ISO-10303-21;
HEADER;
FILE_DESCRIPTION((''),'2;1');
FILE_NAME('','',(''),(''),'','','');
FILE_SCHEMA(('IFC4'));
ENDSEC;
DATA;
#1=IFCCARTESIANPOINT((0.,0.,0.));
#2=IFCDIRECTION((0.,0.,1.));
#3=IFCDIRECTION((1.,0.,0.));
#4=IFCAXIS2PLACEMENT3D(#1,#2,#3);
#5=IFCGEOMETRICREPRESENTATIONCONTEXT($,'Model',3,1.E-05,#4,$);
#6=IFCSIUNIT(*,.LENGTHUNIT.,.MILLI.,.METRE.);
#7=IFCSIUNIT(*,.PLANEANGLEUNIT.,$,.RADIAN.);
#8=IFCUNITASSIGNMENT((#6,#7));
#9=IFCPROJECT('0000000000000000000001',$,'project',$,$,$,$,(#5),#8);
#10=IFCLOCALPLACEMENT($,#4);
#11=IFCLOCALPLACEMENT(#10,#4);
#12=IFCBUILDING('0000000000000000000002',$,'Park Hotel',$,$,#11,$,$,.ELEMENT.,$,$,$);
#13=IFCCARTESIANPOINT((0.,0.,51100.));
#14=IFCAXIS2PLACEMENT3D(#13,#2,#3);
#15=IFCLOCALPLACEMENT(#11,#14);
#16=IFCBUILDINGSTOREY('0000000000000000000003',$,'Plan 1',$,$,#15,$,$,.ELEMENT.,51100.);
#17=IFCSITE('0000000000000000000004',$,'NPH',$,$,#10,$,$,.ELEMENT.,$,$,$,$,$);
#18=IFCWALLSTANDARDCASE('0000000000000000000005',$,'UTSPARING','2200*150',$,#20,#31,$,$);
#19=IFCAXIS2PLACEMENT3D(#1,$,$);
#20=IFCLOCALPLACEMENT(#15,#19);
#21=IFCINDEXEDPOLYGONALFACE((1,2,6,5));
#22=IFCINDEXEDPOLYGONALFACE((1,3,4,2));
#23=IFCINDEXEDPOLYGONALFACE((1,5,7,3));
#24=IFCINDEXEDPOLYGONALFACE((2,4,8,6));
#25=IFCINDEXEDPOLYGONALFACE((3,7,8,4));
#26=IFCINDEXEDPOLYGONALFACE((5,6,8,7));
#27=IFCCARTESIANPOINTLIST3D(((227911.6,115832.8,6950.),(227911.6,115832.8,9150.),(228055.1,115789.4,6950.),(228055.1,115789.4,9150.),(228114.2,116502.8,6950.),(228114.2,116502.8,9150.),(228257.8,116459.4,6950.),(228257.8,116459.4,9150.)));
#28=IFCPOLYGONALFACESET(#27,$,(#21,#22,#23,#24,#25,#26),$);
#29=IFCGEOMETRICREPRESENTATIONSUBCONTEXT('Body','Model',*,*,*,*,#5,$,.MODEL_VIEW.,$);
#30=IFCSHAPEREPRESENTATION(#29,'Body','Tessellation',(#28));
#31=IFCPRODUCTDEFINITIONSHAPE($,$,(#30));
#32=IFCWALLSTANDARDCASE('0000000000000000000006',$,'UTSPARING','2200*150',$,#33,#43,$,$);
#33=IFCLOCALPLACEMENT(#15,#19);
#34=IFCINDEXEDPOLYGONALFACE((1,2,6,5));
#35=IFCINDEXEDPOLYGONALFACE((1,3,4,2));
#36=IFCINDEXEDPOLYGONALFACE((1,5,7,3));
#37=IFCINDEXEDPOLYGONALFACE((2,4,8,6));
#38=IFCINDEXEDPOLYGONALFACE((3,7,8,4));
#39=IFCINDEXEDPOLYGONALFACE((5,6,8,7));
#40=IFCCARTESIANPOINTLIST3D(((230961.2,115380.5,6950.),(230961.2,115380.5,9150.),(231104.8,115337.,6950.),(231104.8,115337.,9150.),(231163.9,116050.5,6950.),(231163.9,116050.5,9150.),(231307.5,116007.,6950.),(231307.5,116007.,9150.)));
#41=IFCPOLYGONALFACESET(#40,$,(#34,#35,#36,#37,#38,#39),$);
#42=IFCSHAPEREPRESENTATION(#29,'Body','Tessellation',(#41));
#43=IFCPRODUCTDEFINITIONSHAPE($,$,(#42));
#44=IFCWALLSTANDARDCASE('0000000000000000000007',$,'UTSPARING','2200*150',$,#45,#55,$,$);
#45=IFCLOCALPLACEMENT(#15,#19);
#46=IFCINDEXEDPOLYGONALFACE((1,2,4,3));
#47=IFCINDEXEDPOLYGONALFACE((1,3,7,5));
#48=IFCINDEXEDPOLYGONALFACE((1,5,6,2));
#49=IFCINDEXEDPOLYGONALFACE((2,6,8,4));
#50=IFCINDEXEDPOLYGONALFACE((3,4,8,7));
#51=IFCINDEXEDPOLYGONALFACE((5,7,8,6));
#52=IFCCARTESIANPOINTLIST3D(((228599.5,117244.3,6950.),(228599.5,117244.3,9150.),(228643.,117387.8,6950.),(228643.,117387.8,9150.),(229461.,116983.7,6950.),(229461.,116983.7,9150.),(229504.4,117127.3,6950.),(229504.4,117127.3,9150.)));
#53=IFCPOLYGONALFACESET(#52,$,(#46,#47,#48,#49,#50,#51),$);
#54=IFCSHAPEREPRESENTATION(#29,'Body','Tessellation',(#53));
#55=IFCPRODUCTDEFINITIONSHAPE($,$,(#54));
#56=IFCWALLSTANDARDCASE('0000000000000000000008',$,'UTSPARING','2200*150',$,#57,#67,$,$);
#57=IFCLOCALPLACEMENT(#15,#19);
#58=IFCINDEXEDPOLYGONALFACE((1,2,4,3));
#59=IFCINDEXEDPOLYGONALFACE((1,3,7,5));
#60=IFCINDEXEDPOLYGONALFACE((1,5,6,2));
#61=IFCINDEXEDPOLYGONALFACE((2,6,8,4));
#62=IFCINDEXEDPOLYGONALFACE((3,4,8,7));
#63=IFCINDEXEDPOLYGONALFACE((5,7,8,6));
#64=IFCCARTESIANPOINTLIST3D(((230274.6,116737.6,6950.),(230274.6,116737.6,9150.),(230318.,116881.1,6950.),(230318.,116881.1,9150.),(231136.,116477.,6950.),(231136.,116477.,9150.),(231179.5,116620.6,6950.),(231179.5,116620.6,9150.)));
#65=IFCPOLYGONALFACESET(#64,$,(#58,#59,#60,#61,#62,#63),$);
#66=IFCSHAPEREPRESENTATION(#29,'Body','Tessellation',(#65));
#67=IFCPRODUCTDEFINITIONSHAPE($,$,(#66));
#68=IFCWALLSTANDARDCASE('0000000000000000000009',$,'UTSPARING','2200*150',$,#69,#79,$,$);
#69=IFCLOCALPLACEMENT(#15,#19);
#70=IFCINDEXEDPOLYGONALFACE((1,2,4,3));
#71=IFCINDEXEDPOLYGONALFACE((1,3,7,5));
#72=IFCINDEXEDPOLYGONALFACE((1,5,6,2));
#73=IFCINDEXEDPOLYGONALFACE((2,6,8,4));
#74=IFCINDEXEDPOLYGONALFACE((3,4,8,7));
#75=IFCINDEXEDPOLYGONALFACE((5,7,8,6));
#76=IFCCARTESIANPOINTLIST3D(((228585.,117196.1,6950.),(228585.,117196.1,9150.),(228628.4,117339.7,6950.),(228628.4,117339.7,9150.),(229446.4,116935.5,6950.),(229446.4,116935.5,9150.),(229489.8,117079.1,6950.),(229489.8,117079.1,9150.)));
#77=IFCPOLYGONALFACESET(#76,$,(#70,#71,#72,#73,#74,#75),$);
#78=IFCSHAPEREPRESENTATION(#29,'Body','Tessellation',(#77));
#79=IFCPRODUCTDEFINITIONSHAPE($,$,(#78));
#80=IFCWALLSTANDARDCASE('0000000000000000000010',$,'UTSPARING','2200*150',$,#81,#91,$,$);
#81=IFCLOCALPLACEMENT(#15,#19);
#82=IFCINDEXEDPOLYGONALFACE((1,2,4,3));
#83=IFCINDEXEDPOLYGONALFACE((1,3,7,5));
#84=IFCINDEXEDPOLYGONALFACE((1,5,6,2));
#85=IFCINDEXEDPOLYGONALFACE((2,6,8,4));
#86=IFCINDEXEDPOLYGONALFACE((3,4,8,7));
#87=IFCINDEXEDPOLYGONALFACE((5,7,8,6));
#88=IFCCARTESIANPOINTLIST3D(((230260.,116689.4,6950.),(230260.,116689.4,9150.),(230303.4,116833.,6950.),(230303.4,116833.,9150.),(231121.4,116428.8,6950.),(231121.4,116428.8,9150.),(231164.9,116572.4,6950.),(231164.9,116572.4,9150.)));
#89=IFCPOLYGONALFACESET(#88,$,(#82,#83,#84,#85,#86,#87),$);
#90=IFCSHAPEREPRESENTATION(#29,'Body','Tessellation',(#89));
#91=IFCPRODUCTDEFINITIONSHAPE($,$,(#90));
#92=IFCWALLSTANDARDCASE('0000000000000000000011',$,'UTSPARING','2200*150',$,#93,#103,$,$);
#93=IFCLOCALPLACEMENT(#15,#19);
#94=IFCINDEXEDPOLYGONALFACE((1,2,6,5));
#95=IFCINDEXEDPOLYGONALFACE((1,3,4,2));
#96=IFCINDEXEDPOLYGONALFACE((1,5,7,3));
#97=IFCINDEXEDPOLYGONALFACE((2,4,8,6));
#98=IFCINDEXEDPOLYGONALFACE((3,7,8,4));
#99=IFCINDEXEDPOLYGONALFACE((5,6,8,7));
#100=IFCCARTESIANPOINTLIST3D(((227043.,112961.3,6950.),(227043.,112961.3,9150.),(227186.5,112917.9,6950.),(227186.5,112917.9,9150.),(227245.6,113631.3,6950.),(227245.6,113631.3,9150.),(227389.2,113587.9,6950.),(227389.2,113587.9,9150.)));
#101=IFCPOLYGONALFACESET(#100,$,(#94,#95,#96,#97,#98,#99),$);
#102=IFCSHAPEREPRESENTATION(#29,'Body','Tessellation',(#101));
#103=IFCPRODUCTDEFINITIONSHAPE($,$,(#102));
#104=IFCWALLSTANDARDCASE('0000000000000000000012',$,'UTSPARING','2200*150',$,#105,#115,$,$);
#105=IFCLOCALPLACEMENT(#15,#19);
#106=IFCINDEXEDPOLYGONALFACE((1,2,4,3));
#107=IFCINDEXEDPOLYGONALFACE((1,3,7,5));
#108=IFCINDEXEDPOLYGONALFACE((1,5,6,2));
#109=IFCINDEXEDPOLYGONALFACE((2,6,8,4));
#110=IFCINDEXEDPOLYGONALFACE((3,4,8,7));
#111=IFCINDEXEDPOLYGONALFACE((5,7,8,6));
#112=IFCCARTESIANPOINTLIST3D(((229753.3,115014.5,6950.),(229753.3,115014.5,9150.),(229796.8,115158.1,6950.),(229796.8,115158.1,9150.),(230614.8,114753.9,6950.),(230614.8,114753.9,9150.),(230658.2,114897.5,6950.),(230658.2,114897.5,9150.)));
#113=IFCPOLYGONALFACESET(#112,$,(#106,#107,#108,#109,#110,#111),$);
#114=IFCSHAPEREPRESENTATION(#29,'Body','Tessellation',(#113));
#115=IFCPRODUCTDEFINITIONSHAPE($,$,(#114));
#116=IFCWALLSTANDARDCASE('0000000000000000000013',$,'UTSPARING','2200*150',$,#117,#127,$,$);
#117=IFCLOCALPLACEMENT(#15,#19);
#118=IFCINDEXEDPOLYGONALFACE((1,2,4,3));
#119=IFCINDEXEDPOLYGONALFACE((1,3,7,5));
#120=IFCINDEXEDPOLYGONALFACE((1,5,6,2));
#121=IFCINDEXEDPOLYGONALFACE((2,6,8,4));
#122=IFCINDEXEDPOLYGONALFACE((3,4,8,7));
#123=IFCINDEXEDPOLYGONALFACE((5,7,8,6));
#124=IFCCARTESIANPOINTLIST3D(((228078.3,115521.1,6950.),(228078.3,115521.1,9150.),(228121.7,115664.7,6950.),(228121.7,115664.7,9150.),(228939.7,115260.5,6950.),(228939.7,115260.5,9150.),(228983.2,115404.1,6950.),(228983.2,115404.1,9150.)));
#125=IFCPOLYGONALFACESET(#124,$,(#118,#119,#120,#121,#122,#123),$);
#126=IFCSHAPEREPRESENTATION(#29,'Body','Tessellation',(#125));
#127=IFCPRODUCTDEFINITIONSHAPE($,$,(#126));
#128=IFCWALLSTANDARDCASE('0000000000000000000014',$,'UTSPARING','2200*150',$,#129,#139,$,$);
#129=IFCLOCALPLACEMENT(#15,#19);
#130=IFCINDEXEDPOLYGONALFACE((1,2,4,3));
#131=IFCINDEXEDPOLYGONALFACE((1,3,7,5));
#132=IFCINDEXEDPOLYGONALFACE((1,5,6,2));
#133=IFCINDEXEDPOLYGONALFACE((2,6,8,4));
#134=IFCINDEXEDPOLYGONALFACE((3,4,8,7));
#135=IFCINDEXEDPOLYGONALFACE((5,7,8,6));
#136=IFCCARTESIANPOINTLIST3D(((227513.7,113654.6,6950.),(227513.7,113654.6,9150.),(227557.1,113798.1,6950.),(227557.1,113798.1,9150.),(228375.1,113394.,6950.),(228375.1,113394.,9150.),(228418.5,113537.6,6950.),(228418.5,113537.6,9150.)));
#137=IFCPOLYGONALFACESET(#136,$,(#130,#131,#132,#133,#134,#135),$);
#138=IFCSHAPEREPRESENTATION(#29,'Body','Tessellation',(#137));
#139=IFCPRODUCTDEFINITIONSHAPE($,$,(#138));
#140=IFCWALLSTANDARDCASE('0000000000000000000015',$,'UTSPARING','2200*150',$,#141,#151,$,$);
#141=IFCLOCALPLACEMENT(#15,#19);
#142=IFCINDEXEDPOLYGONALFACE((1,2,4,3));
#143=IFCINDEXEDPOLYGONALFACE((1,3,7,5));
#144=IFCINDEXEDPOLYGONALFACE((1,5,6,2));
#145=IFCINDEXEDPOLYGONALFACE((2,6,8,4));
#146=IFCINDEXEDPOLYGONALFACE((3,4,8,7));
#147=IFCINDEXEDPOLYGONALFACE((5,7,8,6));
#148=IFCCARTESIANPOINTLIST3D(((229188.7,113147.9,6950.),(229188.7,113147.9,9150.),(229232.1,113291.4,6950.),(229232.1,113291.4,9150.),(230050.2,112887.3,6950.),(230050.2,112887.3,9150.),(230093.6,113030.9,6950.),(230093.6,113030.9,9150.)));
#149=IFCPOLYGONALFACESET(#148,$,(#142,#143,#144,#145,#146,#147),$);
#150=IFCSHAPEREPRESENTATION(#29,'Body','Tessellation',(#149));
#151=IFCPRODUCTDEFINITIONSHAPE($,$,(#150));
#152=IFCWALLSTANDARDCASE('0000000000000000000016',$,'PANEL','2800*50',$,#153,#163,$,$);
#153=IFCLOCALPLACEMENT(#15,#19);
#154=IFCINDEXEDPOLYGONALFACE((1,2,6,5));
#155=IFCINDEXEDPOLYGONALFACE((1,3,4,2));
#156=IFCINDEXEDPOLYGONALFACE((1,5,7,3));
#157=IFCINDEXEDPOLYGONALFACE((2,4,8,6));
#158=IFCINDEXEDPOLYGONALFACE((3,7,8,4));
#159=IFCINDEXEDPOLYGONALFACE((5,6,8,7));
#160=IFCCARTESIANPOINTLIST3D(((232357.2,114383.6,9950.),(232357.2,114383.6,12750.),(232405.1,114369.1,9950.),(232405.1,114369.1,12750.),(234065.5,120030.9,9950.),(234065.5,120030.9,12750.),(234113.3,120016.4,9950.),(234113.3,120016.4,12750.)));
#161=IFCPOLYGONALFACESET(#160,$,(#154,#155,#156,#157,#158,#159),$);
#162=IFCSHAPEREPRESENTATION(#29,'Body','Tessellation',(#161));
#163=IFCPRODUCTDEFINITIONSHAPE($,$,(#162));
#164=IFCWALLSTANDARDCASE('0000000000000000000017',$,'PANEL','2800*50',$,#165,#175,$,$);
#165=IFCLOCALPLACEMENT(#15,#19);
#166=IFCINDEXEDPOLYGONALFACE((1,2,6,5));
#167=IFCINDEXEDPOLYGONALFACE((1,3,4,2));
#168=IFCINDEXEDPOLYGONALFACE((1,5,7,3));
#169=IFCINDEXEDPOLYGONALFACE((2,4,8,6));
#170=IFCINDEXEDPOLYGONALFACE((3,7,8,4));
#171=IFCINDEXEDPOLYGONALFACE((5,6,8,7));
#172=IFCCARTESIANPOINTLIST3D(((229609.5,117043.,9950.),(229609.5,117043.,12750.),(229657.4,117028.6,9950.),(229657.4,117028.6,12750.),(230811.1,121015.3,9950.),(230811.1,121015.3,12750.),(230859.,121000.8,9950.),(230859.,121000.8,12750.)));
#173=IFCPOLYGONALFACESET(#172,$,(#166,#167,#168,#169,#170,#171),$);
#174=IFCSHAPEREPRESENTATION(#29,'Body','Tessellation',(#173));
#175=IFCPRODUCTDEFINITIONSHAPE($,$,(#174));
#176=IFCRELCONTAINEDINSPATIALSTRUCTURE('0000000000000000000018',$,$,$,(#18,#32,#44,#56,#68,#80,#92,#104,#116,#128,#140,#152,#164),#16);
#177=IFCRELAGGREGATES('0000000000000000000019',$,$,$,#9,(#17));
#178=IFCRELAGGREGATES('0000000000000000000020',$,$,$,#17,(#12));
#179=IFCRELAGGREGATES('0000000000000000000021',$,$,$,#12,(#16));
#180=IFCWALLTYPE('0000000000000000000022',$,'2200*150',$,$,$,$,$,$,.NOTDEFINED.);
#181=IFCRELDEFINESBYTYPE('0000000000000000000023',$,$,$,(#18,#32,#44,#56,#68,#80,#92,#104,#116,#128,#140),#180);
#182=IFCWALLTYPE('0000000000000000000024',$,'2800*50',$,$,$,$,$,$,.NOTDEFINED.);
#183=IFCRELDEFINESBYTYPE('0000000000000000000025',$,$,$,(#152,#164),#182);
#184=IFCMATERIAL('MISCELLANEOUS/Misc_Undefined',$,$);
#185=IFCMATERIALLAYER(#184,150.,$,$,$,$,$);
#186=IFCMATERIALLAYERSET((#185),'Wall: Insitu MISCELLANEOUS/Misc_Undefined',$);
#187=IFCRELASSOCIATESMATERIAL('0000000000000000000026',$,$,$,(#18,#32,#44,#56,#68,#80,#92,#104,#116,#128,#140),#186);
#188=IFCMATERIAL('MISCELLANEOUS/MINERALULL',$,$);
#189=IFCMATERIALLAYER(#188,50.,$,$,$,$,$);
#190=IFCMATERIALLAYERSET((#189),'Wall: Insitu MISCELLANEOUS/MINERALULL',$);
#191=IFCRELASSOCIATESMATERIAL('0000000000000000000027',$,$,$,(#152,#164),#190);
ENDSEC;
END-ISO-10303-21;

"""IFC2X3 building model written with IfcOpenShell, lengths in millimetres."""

from ifc_helpers import new_model, si_unit, frame, frame_2d, origin_with_axes, place, context, subcontext, project, spatial, rectangle, extrude, material, layer, layer_set, layer_usage, type_object, element, save


model = new_model("IFC2X3")

# Units and contexts
model_context = context("Model", 3, precision=1e-05, world=origin_with_axes())
body_context = subcontext(model_context, "Body", "Model", "MODEL_VIEW")
ifc_project = project(units=[si_unit("LENGTHUNIT", "METRE", prefix="MILLI"), si_unit("PLANEANGLEUNIT", "RADIAN")], contexts=[model_context])

# Site, building, storey
site_placement = place(None, origin_with_axes())
site = spatial("IfcSite", under=ifc_project, at=site_placement, Name="NPH", CompositionType="ELEMENT")
building_placement = place(site_placement, origin_with_axes())
building = spatial("IfcBuilding", under=site, at=building_placement, Name="Park Hotel", CompositionType="ELEMENT")
storey_placement = place(building_placement, frame((0.0, 0.0, 51100.0), z_axis=(0.0, 0.0, 1.0), x_axis=(1.0, 0.0, 0.0)))
storey = spatial("IfcBuildingStorey", under=building, at=storey_placement, Name="Plan 1", CompositionType="ELEMENT", Elevation=51100.0)

# Walls
ifc_material_1 = material(Name="MISCELLANEOUS/Misc_Undefined")
ifc_layer_1 = layer(ifc_material_1, 150.0)
ifc_layer_set_1 = layer_set([ifc_layer_1], Name="Wall: Insitu MISCELLANEOUS/Misc_Undefined")
ifc_layer_usage_1 = layer_usage(ifc_layer_set_1, "AXIS2", "POSITIVE", -75.0)
wall_type_1 = type_object("IfcWallType", Name="2200*150", PredefinedType="NOTDEFINED")
wall_1_placement = place(storey_placement, frame((228186.0, 116481.1, 6950.0), z_axis=(0.0, 0.0, 1.0), x_axis=(-0.289534, -0.957168, 0.0)))
element("IfcWallStandardCase", 1, at=wall_1_placement, inside=storey, type_object=wall_type_1, material=ifc_layer_usage_1, Name="UTSPARING", Description="2200*150", context=body_context, shape_type="SweptSolid", body=[
    extrude(rectangle(XDim=700.0, YDim=150.0, at=frame_2d((0.0, 350.0), x_axis=(0.0, -1.0))), frame((0.0, 0.0, 0.0), z_axis=(0.0, 0.0, 1.0), x_axis=(0.0, -1.0, 0.0)), (0.0, 0.0, 1.0), 2200.0),
])
ifc_layer_usage_2 = layer_usage(ifc_layer_set_1, "AXIS2", "POSITIVE", -75.0)
wall_2_placement = place(storey_placement, frame((231235.7, 116028.8, 6950.0), z_axis=(0.0, 0.0, 1.0), x_axis=(-0.289534, -0.957168, 0.0)))
element("IfcWallStandardCase", 2, at=wall_2_placement, inside=storey, type_object=wall_type_1, material=ifc_layer_usage_2, Name="UTSPARING", Description="2200*150", context=body_context, shape_type="SweptSolid", body=[
    extrude(rectangle(XDim=700.0, YDim=150.0, at=frame_2d((0.0, 350.0), x_axis=(0.0, -1.0))), frame((0.0, 0.0, 0.0), z_axis=(0.0, 0.0, 1.0), x_axis=(0.0, -1.0, 0.0)), (0.0, 0.0, 1.0), 2200.0),
])
ifc_layer_usage_3 = layer_usage(ifc_layer_set_1, "AXIS2", "POSITIVE", -75.0)
wall_3_placement = place(storey_placement, frame((228621.2, 117316.0, 6950.0), z_axis=(0.0, 0.0, 1.0), x_axis=(0.957168, -0.289534, 0.0)))
element("IfcWallStandardCase", 3, at=wall_3_placement, inside=storey, type_object=wall_type_1, material=ifc_layer_usage_3, Name="UTSPARING", Description="2200*150", context=body_context, shape_type="SweptSolid", body=[
    extrude(rectangle(XDim=900.0, YDim=150.0, at=frame_2d((0.0, 450.0), x_axis=(0.0, -1.0))), frame((0.0, 0.0, 0.0), z_axis=(0.0, 0.0, 1.0), x_axis=(0.0, -1.0, 0.0)), (0.0, 0.0, 1.0), 2200.0),
])
ifc_layer_usage_4 = layer_usage(ifc_layer_set_1, "AXIS2", "POSITIVE", -75.0)
wall_4_placement = place(storey_placement, frame((230296.3, 116809.4, 6950.0), z_axis=(0.0, 0.0, 1.0), x_axis=(0.957168, -0.289534, 0.0)))
element("IfcWallStandardCase", 4, at=wall_4_placement, inside=storey, type_object=wall_type_1, material=ifc_layer_usage_4, Name="UTSPARING", Description="2200*150", context=body_context, shape_type="SweptSolid", body=[
    extrude(rectangle(XDim=900.0, YDim=150.0, at=frame_2d((0.0, 450.0), x_axis=(0.0, -1.0))), frame((0.0, 0.0, 0.0), z_axis=(0.0, 0.0, 1.0), x_axis=(0.0, -1.0, 0.0)), (0.0, 0.0, 1.0), 2200.0),
])
ifc_layer_usage_5 = layer_usage(ifc_layer_set_1, "AXIS2", "POSITIVE", -75.0)
wall_5_placement = place(storey_placement, frame((228606.7, 117267.9, 6950.0), z_axis=(0.0, 0.0, 1.0), x_axis=(0.957166, -0.289541, 0.0)))
element("IfcWallStandardCase", 5, at=wall_5_placement, inside=storey, type_object=wall_type_1, material=ifc_layer_usage_5, Name="UTSPARING", Description="2200*150", context=body_context, shape_type="SweptSolid", body=[
    extrude(rectangle(XDim=900.0, YDim=150.0, at=frame_2d((0.0, 450.0), x_axis=(0.0, -1.0))), frame((0.0, 0.0, 0.0), z_axis=(0.0, 0.0, 1.0), x_axis=(0.0, -1.0, 0.0)), (0.0, 0.0, 1.0), 2200.0),
])
ifc_layer_usage_6 = layer_usage(ifc_layer_set_1, "AXIS2", "POSITIVE", -75.0)
wall_6_placement = place(storey_placement, frame((230281.7, 116761.2, 6950.0), z_axis=(0.0, 0.0, 1.0), x_axis=(0.957166, -0.289541, 0.0)))
element("IfcWallStandardCase", 6, at=wall_6_placement, inside=storey, type_object=wall_type_1, material=ifc_layer_usage_6, Name="UTSPARING", Description="2200*150", context=body_context, shape_type="SweptSolid", body=[
    extrude(rectangle(XDim=900.0, YDim=150.0, at=frame_2d((0.0, 450.0), x_axis=(0.0, -1.0))), frame((0.0, 0.0, 0.0), z_axis=(0.0, 0.0, 1.0), x_axis=(0.0, -1.0, 0.0)), (0.0, 0.0, 1.0), 2200.0),
])
ifc_layer_usage_7 = layer_usage(ifc_layer_set_1, "AXIS2", "POSITIVE", -75.0)
wall_7_placement = place(storey_placement, frame((227114.7, 112939.6, 6950.0), z_axis=(0.0, 0.0, 1.0), x_axis=(0.289542, 0.957165, 0.0)))
element("IfcWallStandardCase", 7, at=wall_7_placement, inside=storey, type_object=wall_type_1, material=ifc_layer_usage_7, Name="UTSPARING", Description="2200*150", context=body_context, shape_type="SweptSolid", body=[
    extrude(rectangle(XDim=700.0, YDim=150.0, at=frame_2d((0.0, 350.0), x_axis=(0.0, -1.0))), frame((0.0, 0.0, 0.0), z_axis=(0.0, 0.0, 1.0), x_axis=(0.0, -1.0, 0.0)), (0.0, 0.0, 1.0), 2200.0),
])
ifc_layer_usage_8 = layer_usage(ifc_layer_set_1, "AXIS2", "POSITIVE", -75.0)
wall_8_placement = place(storey_placement, frame((229775.1, 115086.3, 6950.0), z_axis=(0.0, 0.0, 1.0), x_axis=(0.957166, -0.289541, 0.0)))
element("IfcWallStandardCase", 8, at=wall_8_placement, inside=storey, type_object=wall_type_1, material=ifc_layer_usage_8, Name="UTSPARING", Description="2200*150", context=body_context, shape_type="SweptSolid", body=[
    extrude(rectangle(XDim=900.0, YDim=150.0, at=frame_2d((0.0, 450.0), x_axis=(0.0, -1.0))), frame((0.0, 0.0, 0.0), z_axis=(0.0, 0.0, 1.0), x_axis=(0.0, -1.0, 0.0)), (0.0, 0.0, 1.0), 2200.0),
])
ifc_layer_usage_9 = layer_usage(ifc_layer_set_1, "AXIS2", "POSITIVE", -75.0)
wall_9_placement = place(storey_placement, frame((228100.0, 115592.9, 6950.0), z_axis=(0.0, 0.0, 1.0), x_axis=(0.957166, -0.289541, 0.0)))
element("IfcWallStandardCase", 9, at=wall_9_placement, inside=storey, type_object=wall_type_1, material=ifc_layer_usage_9, Name="UTSPARING", Description="2200*150", context=body_context, shape_type="SweptSolid", body=[
    extrude(rectangle(XDim=900.0, YDim=150.0, at=frame_2d((0.0, 450.0), x_axis=(0.0, -1.0))), frame((0.0, 0.0, 0.0), z_axis=(0.0, 0.0, 1.0), x_axis=(0.0, -1.0, 0.0)), (0.0, 0.0, 1.0), 2200.0),
])
ifc_layer_usage_10 = layer_usage(ifc_layer_set_1, "AXIS2", "POSITIVE", -75.0)
wall_10_placement = place(storey_placement, frame((227535.4, 113726.4, 6950.0), z_axis=(0.0, 0.0, 1.0), x_axis=(0.957166, -0.289541, 0.0)))
element("IfcWallStandardCase", 10, at=wall_10_placement, inside=storey, type_object=wall_type_1, material=ifc_layer_usage_10, Name="UTSPARING", Description="2200*150", context=body_context, shape_type="SweptSolid", body=[
    extrude(rectangle(XDim=900.0, YDim=150.0, at=frame_2d((0.0, 450.0), x_axis=(0.0, -1.0))), frame((0.0, 0.0, 0.0), z_axis=(0.0, 0.0, 1.0), x_axis=(0.0, -1.0, 0.0)), (0.0, 0.0, 1.0), 2200.0),
])
ifc_layer_usage_11 = layer_usage(ifc_layer_set_1, "AXIS2", "POSITIVE", -75.0)
wall_11_placement = place(storey_placement, frame((229210.4, 113219.7, 6950.0), z_axis=(0.0, 0.0, 1.0), x_axis=(0.957166, -0.289541, 0.0)))
element("IfcWallStandardCase", 11, at=wall_11_placement, inside=storey, type_object=wall_type_1, material=ifc_layer_usage_11, Name="UTSPARING", Description="2200*150", context=body_context, shape_type="SweptSolid", body=[
    extrude(rectangle(XDim=900.0, YDim=150.0, at=frame_2d((0.0, 450.0), x_axis=(0.0, -1.0))), frame((0.0, 0.0, 0.0), z_axis=(0.0, 0.0, 1.0), x_axis=(0.0, -1.0, 0.0)), (0.0, 0.0, 1.0), 2200.0),
])
ifc_material_2 = material(Name="MISCELLANEOUS/MINERALULL")
ifc_layer_2 = layer(ifc_material_2, 50.0)
ifc_layer_set_2 = layer_set([ifc_layer_2], Name="Wall: Insitu MISCELLANEOUS/MINERALULL")
ifc_layer_usage_12 = layer_usage(ifc_layer_set_2, "AXIS2", "POSITIVE", -25.0)
wall_type_2 = type_object("IfcWallType", Name="2800*50", PredefinedType="NOTDEFINED")
wall_12_placement = place(storey_placement, frame((232381.1, 114376.3, 9950.0), z_axis=(0.0, 0.0, 1.0), x_axis=(0.289537, 0.957167, 0.0)))
element("IfcWallStandardCase", 12, at=wall_12_placement, inside=storey, type_object=wall_type_2, material=ifc_layer_usage_12, Name="PANEL", Description="2800*50", context=body_context, shape_type="SweptSolid", body=[
    extrude(rectangle(XDim=5900.0, YDim=50.0, at=frame_2d((0.0, 2950.0), x_axis=(0.0, -1.0))), frame((0.0, 0.0, 0.0), z_axis=(0.0, 0.0, 1.0), x_axis=(0.0, -1.0, 0.0)), (0.0, 0.0, 1.0), 2800.0),
])
ifc_layer_usage_13 = layer_usage(ifc_layer_set_2, "AXIS2", "POSITIVE", -25.0)
wall_13_placement = place(storey_placement, frame((229633.5, 117035.8, 9950.0), z_axis=(0.0, 0.0, 1.0), x_axis=(0.289537, 0.957167, 0.0)))
element("IfcWallStandardCase", 13, at=wall_13_placement, inside=storey, type_object=wall_type_2, material=ifc_layer_usage_13, Name="PANEL", Description="2800*50", context=body_context, shape_type="SweptSolid", body=[
    extrude(rectangle(XDim=4150.0, YDim=50.0, at=frame_2d((0.0, 2075.0), x_axis=(0.0, -1.0))), frame((0.0, 0.0, 0.0), z_axis=(0.0, 0.0, 1.0), x_axis=(0.0, -1.0, 0.0)), (0.0, 0.0, 1.0), 2800.0),
])

save(model, "model.ifc")
